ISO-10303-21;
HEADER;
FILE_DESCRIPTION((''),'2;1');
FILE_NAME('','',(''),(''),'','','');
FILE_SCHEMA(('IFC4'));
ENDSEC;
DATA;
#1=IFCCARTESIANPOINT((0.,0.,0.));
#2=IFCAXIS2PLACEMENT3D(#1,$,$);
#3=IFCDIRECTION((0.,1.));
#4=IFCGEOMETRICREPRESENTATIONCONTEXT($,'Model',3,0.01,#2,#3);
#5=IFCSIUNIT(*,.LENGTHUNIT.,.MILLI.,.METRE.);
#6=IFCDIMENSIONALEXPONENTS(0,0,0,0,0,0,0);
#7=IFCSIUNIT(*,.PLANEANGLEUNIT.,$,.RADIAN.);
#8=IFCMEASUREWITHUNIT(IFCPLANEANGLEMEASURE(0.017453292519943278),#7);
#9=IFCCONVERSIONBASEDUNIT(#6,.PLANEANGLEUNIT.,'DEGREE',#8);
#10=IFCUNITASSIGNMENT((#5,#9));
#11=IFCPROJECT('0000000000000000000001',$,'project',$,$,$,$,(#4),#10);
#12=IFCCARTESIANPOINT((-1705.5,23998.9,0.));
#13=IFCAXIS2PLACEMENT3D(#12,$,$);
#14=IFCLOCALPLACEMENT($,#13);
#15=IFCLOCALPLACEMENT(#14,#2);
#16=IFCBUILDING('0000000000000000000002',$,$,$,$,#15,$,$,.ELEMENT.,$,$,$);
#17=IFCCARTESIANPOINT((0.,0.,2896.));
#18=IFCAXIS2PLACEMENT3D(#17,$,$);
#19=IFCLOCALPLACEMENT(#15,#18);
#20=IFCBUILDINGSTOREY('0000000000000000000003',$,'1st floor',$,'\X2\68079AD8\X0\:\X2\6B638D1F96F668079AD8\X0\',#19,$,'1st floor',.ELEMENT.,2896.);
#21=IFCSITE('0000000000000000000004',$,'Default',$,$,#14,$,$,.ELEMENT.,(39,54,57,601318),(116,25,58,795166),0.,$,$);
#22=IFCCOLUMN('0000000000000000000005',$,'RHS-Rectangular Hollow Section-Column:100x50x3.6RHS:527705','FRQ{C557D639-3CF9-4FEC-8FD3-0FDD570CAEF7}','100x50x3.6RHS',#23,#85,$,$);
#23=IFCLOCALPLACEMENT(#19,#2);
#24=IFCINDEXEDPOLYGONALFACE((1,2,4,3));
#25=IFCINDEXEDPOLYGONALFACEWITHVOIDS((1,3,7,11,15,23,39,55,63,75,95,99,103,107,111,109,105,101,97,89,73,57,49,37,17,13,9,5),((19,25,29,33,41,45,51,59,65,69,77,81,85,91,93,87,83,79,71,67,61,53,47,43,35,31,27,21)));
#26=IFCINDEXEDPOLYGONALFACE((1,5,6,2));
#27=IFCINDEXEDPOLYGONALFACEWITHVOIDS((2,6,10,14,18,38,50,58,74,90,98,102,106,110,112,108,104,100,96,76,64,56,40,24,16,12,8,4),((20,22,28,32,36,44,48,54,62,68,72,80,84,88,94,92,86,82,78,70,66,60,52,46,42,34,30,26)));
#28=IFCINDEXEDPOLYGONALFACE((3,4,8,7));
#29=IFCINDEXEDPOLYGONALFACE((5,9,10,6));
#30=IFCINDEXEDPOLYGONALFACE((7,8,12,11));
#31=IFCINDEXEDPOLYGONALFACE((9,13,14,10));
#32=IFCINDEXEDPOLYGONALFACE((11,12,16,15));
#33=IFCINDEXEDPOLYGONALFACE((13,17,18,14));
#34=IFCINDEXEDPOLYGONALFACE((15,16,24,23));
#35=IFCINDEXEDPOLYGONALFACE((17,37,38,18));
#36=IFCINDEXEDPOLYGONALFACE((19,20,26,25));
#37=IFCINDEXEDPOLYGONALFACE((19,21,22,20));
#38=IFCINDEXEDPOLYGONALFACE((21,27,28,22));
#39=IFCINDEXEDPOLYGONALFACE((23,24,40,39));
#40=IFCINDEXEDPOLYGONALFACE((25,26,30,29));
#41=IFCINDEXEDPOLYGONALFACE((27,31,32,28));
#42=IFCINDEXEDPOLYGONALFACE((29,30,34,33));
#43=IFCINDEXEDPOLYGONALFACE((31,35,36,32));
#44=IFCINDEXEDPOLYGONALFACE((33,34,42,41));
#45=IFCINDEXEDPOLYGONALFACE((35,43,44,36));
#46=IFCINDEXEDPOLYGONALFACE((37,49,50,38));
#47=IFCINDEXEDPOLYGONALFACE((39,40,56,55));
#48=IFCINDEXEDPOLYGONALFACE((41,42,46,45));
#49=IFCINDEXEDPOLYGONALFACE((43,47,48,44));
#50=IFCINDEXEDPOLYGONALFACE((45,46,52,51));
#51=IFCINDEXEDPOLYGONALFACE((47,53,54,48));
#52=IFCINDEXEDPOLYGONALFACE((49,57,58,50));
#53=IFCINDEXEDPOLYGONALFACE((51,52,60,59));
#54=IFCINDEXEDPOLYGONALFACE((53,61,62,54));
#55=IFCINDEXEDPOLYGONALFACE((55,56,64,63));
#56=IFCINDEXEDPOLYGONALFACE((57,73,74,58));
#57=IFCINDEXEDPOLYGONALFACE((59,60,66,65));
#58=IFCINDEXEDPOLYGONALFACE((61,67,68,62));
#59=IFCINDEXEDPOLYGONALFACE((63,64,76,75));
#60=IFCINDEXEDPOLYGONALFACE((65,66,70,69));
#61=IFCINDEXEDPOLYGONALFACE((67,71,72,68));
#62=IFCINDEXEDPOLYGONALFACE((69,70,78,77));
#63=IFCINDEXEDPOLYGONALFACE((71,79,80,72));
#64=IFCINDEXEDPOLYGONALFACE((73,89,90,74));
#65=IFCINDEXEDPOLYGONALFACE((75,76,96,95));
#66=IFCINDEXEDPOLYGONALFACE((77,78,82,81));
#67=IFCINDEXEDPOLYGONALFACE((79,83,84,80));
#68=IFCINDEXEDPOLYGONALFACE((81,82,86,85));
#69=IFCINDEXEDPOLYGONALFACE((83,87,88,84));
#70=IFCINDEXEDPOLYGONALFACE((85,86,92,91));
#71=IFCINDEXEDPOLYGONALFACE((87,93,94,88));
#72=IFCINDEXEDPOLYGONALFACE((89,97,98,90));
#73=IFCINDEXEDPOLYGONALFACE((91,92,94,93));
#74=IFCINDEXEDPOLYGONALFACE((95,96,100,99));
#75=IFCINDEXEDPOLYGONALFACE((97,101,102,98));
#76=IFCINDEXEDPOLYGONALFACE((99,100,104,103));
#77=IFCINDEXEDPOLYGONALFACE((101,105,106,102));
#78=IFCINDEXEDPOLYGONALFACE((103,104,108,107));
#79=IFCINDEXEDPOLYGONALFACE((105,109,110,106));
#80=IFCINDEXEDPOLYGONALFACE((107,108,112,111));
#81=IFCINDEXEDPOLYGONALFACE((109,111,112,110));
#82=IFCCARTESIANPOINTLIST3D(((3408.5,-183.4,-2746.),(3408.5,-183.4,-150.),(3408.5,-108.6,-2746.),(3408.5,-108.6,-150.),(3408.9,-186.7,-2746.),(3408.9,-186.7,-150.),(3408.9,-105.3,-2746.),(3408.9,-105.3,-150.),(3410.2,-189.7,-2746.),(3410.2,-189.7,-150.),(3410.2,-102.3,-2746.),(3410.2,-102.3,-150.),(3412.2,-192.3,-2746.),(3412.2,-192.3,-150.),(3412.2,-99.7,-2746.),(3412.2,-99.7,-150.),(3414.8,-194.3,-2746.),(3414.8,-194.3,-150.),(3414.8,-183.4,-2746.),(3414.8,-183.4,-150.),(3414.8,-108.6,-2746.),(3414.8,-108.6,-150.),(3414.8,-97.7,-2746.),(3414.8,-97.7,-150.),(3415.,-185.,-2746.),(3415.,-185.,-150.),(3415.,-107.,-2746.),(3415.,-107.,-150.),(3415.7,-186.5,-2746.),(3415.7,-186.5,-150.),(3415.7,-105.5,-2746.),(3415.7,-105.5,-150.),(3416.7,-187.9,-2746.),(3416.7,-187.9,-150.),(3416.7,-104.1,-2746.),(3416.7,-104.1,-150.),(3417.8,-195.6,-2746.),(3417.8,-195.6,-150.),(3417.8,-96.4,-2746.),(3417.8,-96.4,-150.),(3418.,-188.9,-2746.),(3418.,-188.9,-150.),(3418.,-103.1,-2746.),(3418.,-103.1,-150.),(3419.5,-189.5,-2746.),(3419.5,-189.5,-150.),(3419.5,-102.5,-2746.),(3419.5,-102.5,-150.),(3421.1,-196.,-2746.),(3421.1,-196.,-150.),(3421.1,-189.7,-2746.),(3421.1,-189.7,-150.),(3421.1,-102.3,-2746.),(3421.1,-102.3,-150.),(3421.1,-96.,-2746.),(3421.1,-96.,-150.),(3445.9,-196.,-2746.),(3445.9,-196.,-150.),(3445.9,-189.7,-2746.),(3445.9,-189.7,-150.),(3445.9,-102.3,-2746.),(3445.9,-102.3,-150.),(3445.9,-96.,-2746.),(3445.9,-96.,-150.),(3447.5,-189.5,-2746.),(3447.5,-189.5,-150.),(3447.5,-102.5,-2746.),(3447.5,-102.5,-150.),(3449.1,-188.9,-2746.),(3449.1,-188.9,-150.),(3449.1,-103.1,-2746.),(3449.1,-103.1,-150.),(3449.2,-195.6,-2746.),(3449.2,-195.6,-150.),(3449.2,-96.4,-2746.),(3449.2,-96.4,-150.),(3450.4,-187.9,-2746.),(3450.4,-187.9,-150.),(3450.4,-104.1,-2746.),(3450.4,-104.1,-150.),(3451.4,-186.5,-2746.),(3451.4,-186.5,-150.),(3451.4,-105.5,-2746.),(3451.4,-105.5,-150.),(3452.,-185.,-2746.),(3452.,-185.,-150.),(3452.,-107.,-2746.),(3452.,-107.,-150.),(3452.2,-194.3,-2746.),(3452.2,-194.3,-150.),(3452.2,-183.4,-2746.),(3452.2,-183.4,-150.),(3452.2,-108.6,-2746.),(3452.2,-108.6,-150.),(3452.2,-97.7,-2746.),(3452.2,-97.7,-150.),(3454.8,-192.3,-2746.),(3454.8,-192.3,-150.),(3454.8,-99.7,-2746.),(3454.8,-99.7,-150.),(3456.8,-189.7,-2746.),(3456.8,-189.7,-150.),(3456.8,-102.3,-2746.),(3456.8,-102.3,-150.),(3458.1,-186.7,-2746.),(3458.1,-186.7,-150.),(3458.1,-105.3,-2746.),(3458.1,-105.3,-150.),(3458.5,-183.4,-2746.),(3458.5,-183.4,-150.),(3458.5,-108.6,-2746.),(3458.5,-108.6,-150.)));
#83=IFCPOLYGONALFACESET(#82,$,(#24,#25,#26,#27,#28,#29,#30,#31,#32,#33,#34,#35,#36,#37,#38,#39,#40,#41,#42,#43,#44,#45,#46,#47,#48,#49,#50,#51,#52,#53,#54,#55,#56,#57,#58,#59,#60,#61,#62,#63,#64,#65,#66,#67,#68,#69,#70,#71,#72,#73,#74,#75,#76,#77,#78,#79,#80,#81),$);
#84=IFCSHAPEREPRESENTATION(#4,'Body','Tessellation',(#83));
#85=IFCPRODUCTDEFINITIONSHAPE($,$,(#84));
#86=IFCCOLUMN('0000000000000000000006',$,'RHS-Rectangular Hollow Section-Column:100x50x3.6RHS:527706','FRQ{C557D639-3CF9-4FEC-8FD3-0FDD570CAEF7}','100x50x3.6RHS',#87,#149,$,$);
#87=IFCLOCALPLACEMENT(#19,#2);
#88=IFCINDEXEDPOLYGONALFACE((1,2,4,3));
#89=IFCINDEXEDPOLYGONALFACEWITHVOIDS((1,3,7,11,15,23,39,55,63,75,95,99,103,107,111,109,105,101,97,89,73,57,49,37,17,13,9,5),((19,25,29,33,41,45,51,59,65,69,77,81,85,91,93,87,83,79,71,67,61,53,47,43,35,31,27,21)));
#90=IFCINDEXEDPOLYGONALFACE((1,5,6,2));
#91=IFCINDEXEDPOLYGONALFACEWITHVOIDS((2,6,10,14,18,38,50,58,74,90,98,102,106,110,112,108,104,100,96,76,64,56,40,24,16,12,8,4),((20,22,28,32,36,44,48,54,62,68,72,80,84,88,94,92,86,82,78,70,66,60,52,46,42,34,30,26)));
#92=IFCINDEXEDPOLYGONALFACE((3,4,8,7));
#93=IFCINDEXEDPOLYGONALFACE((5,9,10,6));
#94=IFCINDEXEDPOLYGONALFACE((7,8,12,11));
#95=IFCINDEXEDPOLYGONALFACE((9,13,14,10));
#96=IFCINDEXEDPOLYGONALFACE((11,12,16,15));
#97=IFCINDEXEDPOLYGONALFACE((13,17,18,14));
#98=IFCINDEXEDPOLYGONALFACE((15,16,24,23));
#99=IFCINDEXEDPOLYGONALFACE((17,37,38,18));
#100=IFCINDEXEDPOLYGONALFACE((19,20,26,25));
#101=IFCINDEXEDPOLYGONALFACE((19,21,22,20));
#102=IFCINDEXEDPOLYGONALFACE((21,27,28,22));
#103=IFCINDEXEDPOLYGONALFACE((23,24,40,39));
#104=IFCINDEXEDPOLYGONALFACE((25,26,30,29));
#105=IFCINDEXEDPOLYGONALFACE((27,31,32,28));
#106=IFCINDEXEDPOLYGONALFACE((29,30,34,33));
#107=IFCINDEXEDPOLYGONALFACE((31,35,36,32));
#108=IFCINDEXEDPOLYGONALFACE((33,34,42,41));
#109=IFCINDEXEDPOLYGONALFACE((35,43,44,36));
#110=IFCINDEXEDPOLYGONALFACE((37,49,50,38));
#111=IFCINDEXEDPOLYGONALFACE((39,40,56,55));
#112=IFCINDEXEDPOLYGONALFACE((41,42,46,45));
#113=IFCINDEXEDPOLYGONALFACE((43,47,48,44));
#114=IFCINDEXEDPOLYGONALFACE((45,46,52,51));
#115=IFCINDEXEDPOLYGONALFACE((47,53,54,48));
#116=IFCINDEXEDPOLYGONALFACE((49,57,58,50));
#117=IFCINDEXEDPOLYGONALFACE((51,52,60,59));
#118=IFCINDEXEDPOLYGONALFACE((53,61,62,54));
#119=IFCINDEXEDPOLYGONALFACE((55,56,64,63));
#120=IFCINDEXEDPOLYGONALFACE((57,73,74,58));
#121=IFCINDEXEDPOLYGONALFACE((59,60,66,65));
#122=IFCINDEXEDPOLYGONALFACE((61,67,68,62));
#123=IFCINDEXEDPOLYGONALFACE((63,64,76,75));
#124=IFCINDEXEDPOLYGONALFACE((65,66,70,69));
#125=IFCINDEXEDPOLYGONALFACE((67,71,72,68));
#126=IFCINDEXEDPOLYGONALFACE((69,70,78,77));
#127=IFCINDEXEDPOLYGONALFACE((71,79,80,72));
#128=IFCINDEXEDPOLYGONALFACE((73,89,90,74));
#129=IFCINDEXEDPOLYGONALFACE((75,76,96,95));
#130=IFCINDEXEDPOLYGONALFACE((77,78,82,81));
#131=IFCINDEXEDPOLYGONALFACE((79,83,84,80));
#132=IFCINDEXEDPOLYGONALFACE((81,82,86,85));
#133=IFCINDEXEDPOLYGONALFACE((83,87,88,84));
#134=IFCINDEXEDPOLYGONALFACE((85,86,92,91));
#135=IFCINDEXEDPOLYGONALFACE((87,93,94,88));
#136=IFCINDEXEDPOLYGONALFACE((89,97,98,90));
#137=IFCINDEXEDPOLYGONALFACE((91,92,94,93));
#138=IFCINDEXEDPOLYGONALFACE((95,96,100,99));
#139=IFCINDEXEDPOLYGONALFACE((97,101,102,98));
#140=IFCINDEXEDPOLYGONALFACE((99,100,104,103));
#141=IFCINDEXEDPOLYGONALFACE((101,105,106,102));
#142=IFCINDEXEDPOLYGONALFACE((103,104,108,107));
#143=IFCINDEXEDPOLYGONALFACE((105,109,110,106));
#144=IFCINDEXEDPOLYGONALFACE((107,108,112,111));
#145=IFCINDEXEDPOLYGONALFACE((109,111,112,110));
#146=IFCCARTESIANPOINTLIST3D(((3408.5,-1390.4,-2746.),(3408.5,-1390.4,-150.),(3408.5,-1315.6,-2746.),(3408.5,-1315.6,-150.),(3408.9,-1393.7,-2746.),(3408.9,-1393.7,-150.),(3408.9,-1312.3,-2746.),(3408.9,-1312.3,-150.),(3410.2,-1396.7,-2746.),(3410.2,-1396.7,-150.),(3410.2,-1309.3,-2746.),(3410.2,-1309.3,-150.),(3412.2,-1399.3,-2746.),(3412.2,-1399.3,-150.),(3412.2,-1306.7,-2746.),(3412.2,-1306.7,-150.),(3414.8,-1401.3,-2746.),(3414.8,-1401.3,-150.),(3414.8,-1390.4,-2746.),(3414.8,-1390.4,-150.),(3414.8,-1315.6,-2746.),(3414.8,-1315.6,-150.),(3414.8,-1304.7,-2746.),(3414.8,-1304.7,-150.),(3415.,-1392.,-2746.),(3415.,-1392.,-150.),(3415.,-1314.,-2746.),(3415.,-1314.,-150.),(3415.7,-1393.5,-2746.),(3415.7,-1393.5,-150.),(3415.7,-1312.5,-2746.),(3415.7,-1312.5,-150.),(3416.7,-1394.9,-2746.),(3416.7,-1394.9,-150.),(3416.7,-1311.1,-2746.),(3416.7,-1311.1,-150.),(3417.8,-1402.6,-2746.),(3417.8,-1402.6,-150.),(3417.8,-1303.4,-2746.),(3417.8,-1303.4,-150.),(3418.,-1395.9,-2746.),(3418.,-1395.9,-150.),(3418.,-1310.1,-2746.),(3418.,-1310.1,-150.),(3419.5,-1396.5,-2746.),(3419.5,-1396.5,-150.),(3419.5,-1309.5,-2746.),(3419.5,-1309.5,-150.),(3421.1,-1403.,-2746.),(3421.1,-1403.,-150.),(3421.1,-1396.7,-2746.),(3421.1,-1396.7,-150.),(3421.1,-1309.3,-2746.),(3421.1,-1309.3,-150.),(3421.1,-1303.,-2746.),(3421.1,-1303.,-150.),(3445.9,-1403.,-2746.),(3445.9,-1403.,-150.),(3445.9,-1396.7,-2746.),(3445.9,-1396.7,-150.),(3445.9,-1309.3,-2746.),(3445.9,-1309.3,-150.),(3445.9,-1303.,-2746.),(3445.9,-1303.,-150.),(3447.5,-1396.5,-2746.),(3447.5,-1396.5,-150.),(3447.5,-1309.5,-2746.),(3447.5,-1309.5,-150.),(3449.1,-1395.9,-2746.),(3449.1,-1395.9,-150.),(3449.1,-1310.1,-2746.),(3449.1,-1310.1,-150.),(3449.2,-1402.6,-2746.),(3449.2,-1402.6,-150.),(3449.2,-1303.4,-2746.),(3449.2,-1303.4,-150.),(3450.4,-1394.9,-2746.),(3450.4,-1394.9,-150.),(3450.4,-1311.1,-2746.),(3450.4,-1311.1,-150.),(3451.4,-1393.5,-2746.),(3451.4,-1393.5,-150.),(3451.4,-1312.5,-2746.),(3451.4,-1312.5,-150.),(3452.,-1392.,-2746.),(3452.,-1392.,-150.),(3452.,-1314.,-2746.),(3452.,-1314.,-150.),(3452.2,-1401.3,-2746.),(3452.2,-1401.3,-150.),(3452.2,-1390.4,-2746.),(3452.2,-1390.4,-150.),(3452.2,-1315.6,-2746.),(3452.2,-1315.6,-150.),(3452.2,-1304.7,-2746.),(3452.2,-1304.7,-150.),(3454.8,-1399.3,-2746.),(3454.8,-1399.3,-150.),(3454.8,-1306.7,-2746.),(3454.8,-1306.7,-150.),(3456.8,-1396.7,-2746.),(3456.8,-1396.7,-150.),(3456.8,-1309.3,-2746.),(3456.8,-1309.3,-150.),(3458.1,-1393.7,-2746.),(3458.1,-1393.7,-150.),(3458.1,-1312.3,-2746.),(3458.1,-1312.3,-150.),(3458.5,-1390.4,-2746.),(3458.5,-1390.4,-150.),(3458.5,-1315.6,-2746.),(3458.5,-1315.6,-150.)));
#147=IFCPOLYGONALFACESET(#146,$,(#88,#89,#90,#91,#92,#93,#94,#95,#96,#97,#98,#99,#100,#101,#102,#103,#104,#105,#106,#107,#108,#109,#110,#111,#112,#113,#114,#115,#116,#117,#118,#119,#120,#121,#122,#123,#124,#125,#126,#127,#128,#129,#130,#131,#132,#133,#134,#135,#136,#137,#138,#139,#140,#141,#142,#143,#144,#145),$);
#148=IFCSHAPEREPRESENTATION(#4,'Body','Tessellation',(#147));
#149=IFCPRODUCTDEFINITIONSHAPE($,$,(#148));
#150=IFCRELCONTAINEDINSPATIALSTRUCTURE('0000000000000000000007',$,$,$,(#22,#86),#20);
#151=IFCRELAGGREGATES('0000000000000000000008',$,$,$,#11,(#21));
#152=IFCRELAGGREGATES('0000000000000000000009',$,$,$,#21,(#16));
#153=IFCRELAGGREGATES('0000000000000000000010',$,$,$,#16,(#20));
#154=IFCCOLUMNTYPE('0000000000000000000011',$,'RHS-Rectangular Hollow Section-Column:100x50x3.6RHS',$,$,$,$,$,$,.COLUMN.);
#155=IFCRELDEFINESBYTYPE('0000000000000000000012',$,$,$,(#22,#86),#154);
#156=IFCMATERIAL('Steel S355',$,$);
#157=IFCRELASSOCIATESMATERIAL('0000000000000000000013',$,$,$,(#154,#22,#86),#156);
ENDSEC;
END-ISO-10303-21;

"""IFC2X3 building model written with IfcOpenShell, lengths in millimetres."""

from ifc_helpers import new_model, entity, si_unit, converted_unit, direction, frame, origin, origin_2d, place, context, project, spatial, hollow_rectangle, extrude, clip, halfspace, material, type_object, element, save


model = new_model("IFC2X3")

# Units and contexts
model_context = context("Model", 3, precision=0.01, world=origin(), true_north=direction((0.0, 1.0)))
ifc_project = project(units=[si_unit("LENGTHUNIT", "METRE", prefix="MILLI"), converted_unit("PLANEANGLEUNIT", "DEGREE", entity("IfcPlaneAngleMeasure", 0.017453292519943278), si_unit("PLANEANGLEUNIT", "RADIAN"), dimensions=[0, 0, 0, 0, 0, 0, 0])], contexts=[model_context])

# Site, building, storey
site_placement = place(None, frame((-1705.5, 23998.9, 0.0)))
site = spatial("IfcSite", under=ifc_project, at=site_placement, Name="Default", CompositionType="ELEMENT", RefLatitude=(39, 54, 57, 601318), RefLongitude=(116, 25, 58, 795166), RefElevation=0.0)
building_placement = place(site_placement, origin())
building = spatial("IfcBuilding", under=site, at=building_placement, CompositionType="ELEMENT")
storey_placement = place(building_placement, frame((0.0, 0.0, 2896.0)))
storey = spatial("IfcBuildingStorey", under=building, at=storey_placement, Name="1st floor", ObjectType="标高:正负零标高", LongName="1st floor", CompositionType="ELEMENT", Elevation=2896.0)

# Columns
ifc_material_1 = material(Name="Steel S355")
column_type_1 = type_object("IfcColumnType", Name="RHS-Rectangular Hollow Section-Column:100x50x3.6RHS", PredefinedType="COLUMN", material=ifc_material_1)
column_1_placement = place(storey_placement, frame((3433.5, -146.0, -150.0), z_axis=(0.0, 0.0, 1.0), x_axis=(-1.0, 0.0, 0.0)))
element("IfcColumn", 1, at=column_1_placement, inside=storey, type_object=column_type_1, material=ifc_material_1, Name="RHS-Rectangular Hollow Section-Column:100x50x3.6RHS:527705", Description="FRQ{C557D639-3CF9-4FEC-8FD3-0FDD570CAEF7}", ObjectType="100x50x3.6RHS", context=model_context, shape_type="Clipping", body=[
    clip(extrude(hollow_rectangle(XDim=50.0, YDim=100.0, WallThickness=6.3, InnerFilletRadius=6.3, OuterFilletRadius=12.6, at=origin_2d()), origin(), (0.0, 0.0, -1.0), 2651.9), halfspace(frame((3433.5, -146.0, -2596.0), z_axis=(0.0, 0.0, 1.0), x_axis=(-1.0, 0.0, 0.0)), True)),
])
column_2_placement = place(storey_placement, frame((3433.5, -1353.0, -150.0), z_axis=(0.0, 0.0, 1.0), x_axis=(-1.0, 0.0, 0.0)))
element("IfcColumn", 2, at=column_2_placement, inside=storey, type_object=column_type_1, material=ifc_material_1, Name="RHS-Rectangular Hollow Section-Column:100x50x3.6RHS:527706", Description="FRQ{C557D639-3CF9-4FEC-8FD3-0FDD570CAEF7}", ObjectType="100x50x3.6RHS", context=model_context, shape_type="Clipping", body=[
    clip(extrude(hollow_rectangle(XDim=50.0, YDim=100.0, WallThickness=6.3, InnerFilletRadius=6.3, OuterFilletRadius=12.6, at=origin_2d()), origin(), (0.0, 0.0, -1.0), 2651.9), halfspace(frame((3433.5, -1353.0, -2596.0), z_axis=(0.0, 0.0, 1.0), x_axis=(-1.0, 0.0, 0.0)), True)),
])

save(model, "model.ifc")
